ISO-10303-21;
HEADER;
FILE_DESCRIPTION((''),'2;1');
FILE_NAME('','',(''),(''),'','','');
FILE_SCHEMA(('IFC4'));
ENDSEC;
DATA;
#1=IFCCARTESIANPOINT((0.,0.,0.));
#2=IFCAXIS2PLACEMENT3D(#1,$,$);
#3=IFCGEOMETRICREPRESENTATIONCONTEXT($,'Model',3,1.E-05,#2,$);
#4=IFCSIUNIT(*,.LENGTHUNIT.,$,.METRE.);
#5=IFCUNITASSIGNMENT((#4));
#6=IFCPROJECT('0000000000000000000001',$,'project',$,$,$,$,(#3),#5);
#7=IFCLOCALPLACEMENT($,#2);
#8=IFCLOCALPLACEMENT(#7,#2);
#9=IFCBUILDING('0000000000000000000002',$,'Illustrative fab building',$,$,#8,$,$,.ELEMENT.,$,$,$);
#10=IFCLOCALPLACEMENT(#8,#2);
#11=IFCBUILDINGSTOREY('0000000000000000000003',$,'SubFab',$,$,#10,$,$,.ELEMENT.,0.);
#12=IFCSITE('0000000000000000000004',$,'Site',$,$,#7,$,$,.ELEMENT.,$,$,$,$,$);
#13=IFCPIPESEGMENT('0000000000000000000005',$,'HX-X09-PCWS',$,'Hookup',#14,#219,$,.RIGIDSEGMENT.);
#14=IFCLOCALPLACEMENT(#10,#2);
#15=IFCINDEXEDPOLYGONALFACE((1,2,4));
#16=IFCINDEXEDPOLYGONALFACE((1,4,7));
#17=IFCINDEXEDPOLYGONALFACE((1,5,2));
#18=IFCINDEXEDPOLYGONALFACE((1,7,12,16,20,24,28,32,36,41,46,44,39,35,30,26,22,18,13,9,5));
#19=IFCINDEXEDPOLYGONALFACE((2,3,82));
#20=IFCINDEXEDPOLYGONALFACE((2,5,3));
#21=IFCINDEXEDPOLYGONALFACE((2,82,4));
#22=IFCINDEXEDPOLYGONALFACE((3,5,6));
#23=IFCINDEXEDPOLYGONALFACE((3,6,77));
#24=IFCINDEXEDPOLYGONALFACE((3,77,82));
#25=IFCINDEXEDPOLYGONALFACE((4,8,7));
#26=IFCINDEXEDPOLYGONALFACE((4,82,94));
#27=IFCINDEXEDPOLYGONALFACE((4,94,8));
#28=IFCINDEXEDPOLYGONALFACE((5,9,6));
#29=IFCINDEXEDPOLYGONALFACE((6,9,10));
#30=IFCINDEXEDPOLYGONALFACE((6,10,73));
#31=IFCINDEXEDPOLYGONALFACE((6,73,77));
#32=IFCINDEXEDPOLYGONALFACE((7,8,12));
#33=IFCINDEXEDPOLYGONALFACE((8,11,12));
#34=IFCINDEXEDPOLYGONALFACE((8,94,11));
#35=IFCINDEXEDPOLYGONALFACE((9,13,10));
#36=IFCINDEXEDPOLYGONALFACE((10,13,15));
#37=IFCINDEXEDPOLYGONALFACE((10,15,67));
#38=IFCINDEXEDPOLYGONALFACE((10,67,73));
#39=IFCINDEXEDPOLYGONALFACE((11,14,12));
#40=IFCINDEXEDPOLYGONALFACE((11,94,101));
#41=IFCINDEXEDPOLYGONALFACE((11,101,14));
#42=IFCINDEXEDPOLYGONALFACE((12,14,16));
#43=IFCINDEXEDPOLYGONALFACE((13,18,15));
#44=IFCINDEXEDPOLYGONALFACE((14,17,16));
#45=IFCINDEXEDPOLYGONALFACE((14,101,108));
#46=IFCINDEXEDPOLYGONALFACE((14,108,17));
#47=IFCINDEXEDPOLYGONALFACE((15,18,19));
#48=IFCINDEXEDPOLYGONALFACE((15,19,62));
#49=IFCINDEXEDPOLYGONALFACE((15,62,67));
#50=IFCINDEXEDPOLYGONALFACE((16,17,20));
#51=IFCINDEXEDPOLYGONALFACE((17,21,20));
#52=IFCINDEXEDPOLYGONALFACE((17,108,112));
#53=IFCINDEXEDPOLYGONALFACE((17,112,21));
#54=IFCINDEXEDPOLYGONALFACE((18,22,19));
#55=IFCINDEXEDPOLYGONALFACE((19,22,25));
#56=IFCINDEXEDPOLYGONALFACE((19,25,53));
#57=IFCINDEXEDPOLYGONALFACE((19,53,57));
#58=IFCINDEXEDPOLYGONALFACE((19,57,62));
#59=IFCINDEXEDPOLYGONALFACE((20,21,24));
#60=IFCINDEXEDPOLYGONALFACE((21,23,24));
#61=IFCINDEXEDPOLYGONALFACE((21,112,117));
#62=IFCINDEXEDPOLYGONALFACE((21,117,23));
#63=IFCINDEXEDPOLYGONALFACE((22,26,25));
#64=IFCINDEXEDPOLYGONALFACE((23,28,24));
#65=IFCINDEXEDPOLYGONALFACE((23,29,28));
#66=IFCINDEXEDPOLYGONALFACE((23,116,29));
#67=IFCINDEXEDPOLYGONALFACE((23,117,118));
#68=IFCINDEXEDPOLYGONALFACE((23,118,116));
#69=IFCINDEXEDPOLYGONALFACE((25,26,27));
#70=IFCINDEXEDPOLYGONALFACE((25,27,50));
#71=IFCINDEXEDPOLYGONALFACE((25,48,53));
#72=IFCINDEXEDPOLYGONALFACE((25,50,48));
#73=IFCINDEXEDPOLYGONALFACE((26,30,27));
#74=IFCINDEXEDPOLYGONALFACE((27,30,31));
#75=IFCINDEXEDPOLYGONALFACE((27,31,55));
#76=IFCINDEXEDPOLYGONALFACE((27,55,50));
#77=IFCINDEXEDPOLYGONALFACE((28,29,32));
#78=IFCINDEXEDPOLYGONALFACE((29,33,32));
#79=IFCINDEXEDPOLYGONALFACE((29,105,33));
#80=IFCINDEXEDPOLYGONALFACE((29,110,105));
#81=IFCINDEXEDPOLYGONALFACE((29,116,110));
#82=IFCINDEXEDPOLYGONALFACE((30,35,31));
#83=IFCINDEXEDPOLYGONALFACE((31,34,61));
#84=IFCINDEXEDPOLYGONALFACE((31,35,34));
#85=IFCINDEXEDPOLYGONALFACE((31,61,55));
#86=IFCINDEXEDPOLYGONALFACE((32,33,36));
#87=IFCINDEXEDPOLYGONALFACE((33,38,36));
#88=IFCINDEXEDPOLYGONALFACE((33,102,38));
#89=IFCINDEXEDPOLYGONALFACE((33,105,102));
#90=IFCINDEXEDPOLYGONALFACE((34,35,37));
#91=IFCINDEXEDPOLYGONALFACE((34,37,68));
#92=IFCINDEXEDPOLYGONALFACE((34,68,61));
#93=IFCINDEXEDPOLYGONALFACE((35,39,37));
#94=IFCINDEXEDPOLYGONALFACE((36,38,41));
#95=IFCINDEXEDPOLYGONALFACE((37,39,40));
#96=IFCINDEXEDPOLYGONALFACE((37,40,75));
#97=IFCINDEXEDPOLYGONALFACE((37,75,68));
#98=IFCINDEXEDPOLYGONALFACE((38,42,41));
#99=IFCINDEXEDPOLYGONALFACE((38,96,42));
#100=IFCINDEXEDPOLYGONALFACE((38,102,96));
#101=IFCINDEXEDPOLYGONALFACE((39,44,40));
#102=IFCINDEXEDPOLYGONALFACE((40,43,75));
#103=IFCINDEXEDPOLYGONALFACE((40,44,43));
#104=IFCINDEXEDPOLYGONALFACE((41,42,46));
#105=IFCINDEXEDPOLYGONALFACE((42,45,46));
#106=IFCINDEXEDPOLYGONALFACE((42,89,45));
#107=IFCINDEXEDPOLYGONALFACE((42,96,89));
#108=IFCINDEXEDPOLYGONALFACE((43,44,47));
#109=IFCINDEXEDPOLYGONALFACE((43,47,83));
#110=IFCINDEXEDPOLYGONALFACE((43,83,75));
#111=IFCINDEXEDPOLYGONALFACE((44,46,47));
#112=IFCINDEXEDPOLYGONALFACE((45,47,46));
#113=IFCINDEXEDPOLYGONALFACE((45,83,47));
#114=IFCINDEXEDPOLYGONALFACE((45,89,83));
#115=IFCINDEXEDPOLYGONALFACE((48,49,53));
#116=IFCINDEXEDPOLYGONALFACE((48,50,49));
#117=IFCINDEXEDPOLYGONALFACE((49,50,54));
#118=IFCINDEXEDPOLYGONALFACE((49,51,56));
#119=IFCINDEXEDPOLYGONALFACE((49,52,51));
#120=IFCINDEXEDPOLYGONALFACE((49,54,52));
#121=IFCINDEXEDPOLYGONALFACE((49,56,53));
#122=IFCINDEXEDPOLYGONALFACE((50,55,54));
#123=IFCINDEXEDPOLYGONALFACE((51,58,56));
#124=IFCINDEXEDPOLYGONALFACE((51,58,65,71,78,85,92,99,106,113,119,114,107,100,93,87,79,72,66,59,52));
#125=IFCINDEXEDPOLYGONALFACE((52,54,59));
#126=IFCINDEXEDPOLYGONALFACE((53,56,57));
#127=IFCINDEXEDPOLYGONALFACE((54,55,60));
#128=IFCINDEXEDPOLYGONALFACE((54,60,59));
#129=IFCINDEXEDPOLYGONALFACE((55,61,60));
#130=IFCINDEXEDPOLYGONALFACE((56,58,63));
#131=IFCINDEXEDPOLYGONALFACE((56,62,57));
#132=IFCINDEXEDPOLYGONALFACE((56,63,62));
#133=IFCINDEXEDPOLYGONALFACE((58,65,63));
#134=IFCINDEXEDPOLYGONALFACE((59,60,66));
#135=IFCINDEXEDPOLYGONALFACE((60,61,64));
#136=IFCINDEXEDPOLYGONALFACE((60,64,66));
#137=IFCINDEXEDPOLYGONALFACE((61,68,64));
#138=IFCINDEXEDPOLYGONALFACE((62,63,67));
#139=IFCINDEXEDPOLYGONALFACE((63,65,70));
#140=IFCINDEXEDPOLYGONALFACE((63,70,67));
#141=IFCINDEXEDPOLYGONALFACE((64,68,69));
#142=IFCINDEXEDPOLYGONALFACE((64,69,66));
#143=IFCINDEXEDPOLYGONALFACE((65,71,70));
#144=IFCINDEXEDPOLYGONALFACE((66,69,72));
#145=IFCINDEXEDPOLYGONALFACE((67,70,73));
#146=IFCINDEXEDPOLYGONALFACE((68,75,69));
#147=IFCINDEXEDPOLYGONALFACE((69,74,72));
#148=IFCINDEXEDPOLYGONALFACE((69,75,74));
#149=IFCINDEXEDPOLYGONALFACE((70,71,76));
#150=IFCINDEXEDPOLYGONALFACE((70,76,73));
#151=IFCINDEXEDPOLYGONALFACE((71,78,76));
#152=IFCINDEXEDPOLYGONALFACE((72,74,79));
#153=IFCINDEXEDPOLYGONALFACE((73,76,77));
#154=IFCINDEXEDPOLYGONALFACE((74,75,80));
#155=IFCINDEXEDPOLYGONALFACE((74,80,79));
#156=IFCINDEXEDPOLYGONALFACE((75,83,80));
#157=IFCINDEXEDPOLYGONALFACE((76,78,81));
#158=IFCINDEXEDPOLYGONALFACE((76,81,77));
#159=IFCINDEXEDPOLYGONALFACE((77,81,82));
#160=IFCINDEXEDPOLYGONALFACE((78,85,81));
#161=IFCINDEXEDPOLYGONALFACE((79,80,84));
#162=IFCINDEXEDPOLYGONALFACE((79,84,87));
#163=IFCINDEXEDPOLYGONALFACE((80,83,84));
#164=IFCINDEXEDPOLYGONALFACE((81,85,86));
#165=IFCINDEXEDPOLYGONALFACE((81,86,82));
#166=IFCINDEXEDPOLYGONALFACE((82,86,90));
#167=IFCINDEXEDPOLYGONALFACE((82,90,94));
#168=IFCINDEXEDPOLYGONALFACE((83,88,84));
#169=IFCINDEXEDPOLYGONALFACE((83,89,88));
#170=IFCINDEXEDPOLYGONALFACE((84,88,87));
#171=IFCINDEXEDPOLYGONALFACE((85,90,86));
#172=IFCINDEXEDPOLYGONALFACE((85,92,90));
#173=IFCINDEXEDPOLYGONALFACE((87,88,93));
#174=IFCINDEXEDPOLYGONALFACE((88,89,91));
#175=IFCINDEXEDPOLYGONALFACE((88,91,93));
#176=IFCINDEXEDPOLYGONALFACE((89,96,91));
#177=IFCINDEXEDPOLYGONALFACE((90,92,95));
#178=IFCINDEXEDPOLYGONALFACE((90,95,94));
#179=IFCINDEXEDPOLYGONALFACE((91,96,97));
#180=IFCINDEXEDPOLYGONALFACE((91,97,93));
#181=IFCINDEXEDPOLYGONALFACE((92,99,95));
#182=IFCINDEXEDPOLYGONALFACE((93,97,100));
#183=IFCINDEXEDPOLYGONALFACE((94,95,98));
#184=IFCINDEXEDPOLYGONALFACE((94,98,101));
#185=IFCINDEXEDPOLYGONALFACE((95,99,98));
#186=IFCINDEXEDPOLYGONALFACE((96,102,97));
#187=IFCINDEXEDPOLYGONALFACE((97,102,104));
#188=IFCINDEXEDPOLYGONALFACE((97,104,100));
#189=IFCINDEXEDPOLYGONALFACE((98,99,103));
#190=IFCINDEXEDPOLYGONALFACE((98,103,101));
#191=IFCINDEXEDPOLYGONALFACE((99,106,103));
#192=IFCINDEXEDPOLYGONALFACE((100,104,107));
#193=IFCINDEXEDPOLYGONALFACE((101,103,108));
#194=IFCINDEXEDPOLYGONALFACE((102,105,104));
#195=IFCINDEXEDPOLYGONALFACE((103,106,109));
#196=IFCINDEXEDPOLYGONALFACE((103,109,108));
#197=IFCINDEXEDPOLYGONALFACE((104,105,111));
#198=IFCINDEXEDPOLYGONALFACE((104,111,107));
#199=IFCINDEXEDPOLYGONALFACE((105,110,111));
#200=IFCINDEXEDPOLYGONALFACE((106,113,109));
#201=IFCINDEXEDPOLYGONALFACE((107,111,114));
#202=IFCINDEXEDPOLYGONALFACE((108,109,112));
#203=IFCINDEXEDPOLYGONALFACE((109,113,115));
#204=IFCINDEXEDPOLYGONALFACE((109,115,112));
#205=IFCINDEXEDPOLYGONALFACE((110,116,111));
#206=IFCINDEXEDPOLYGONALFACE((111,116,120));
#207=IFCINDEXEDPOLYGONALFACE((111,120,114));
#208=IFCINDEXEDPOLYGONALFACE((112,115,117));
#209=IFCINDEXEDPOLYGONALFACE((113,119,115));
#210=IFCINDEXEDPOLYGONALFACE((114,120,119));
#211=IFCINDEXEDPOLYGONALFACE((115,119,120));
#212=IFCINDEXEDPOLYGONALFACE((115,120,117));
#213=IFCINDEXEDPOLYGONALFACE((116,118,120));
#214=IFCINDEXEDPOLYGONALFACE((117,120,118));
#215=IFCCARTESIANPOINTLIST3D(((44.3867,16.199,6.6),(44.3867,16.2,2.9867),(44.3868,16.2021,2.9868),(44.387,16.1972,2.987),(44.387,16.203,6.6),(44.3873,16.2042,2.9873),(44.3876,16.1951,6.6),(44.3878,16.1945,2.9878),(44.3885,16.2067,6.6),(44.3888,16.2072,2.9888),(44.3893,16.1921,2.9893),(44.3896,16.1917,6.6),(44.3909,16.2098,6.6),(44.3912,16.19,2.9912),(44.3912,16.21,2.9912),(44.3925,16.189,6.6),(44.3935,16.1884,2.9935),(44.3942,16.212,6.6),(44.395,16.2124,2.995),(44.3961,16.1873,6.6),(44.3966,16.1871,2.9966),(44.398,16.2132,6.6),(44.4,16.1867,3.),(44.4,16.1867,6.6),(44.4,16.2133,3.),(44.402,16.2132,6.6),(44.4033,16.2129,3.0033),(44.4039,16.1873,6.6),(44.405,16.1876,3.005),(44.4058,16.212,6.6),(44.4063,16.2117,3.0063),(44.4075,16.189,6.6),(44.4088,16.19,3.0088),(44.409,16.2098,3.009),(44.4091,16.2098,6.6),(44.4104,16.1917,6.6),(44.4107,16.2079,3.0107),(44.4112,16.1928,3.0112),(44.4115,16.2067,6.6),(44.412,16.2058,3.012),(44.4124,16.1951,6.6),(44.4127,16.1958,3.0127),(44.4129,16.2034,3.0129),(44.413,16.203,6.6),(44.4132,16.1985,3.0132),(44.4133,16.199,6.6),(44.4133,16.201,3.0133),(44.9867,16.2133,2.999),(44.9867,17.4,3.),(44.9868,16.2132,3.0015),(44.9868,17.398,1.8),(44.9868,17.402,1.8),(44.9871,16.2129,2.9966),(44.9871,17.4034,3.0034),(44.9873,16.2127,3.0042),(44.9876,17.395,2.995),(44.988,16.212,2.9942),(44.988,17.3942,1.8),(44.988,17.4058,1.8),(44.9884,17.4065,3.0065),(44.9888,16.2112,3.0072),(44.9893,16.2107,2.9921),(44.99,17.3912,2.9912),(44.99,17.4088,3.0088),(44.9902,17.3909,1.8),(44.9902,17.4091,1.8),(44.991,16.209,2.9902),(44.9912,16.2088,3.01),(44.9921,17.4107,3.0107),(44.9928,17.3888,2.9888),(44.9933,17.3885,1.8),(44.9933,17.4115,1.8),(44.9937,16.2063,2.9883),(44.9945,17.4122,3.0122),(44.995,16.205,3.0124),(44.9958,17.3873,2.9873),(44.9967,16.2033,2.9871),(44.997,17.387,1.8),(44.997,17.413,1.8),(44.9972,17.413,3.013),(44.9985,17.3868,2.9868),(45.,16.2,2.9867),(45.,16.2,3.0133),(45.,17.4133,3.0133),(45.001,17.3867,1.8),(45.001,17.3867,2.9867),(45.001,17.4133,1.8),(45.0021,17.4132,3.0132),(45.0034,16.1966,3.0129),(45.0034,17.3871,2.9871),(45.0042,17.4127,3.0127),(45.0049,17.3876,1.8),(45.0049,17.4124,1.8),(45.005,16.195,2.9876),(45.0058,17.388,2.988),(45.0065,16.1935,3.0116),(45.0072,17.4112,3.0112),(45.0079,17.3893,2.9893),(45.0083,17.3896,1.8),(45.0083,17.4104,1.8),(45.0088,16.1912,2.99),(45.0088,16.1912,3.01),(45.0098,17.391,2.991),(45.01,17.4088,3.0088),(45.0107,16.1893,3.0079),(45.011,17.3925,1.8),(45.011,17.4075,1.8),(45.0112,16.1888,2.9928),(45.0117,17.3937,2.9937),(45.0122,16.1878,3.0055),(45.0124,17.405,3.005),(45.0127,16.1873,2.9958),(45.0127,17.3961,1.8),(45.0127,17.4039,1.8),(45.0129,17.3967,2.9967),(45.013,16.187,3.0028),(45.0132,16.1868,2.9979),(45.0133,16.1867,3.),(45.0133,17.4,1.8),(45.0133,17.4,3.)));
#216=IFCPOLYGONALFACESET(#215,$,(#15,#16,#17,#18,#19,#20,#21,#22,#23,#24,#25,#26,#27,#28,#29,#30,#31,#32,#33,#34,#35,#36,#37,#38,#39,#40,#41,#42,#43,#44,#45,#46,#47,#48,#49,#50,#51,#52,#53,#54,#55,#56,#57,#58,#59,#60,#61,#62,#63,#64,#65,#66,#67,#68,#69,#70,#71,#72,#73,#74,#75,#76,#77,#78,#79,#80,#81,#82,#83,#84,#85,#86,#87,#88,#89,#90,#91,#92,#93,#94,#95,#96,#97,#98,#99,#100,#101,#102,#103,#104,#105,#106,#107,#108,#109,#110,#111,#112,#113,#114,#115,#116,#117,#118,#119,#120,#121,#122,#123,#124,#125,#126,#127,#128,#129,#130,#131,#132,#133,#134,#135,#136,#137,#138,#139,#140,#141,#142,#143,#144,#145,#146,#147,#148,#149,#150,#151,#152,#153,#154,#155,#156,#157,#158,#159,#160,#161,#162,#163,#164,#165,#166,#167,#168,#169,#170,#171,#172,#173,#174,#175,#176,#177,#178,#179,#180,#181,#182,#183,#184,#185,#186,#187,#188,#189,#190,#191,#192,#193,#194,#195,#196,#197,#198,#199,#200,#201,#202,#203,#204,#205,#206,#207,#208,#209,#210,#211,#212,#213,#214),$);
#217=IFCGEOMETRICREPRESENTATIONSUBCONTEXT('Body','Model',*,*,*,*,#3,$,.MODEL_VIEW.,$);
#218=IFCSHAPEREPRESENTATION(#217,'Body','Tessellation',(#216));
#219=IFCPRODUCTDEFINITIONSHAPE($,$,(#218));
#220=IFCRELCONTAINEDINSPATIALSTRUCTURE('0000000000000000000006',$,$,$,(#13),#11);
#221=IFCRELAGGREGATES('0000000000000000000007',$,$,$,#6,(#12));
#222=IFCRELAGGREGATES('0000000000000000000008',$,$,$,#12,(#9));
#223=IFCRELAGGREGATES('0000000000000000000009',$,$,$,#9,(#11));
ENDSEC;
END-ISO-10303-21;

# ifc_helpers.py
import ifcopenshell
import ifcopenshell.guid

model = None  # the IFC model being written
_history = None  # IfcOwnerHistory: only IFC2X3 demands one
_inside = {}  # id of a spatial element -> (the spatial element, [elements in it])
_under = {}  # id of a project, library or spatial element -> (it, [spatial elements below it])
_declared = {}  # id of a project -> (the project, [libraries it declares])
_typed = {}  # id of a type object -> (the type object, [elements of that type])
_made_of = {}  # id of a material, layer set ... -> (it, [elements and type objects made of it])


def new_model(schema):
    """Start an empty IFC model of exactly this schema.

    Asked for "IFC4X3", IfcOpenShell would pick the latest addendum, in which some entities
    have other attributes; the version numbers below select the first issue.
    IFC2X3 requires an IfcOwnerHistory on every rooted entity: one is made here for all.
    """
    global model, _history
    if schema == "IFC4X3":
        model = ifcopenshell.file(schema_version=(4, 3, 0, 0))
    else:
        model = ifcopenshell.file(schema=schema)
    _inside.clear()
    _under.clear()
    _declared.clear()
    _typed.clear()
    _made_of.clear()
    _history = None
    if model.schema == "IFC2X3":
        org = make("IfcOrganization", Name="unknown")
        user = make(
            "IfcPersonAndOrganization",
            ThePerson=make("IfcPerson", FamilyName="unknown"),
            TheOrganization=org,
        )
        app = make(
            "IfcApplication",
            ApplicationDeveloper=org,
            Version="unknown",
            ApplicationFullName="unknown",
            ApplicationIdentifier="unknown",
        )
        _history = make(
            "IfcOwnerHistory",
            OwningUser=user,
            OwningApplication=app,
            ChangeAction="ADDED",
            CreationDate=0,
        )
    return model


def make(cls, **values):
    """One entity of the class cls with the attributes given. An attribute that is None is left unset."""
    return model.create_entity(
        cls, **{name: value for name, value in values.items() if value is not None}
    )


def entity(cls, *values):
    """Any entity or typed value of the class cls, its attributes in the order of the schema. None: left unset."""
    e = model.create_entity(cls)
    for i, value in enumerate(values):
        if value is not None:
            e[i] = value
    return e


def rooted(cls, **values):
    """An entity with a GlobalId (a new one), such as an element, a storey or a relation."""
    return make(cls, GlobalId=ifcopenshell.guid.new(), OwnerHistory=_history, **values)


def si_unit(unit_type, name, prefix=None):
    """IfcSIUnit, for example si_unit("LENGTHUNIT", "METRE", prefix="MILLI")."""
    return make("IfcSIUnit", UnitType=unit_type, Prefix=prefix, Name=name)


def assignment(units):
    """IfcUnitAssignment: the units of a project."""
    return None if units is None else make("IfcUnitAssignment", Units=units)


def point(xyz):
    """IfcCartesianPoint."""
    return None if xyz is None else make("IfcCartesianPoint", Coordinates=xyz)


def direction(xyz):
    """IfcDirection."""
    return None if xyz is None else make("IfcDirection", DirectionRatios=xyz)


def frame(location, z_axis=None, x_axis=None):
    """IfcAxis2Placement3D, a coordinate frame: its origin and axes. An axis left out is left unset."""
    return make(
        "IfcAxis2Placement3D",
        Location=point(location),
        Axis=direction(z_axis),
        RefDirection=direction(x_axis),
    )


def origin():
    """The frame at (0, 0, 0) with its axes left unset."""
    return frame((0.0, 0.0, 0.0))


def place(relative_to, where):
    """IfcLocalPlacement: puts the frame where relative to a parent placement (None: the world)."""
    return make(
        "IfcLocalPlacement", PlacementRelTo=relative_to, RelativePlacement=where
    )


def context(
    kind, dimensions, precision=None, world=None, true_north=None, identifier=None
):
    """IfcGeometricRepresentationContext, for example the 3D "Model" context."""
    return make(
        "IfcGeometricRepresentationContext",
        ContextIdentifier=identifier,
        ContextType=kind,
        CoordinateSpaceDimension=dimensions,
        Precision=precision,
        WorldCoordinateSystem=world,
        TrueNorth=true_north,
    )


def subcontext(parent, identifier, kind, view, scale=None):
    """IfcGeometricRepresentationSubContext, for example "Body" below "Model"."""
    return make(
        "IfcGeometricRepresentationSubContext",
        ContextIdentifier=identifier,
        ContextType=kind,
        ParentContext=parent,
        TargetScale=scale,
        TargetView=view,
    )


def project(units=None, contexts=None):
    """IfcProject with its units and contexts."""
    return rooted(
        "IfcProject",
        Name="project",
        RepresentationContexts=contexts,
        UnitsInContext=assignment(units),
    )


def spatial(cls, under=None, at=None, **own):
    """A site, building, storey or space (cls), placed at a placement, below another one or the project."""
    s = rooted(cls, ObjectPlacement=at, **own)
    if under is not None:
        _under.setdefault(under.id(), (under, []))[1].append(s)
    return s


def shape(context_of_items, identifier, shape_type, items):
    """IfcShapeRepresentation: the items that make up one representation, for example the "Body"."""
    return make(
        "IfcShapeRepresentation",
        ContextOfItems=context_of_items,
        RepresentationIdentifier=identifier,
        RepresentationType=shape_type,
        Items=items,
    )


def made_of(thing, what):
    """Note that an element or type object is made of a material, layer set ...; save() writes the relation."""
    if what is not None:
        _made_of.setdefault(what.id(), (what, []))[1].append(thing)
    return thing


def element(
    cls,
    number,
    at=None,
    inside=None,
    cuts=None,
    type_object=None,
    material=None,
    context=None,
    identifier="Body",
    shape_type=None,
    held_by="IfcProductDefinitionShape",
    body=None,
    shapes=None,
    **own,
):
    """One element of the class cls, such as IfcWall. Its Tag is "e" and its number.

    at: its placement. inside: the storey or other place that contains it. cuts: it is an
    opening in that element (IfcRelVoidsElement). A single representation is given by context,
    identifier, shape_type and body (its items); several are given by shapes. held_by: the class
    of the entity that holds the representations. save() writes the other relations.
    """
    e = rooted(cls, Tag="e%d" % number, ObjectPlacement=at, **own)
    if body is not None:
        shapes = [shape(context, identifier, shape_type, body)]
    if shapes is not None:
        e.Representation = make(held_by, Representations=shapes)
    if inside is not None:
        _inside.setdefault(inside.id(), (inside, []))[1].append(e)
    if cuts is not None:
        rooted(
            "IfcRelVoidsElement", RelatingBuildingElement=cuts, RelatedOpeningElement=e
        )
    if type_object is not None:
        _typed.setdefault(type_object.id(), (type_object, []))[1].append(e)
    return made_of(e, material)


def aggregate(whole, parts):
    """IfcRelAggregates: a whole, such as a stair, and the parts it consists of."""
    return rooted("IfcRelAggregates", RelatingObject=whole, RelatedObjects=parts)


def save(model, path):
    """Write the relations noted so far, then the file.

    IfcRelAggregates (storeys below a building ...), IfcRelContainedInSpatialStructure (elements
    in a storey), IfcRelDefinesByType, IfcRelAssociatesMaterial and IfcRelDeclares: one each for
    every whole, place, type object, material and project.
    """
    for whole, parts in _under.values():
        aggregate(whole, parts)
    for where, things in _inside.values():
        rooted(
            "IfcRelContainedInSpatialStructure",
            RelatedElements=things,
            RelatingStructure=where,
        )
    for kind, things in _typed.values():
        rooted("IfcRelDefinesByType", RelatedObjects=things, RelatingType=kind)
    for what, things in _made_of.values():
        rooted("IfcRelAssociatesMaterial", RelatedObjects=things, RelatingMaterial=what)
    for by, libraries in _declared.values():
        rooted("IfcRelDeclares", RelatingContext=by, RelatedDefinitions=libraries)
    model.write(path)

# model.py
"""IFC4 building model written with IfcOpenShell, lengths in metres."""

from ifc_helpers import new_model, entity, si_unit, origin, place, context, subcontext, project, spatial, element, save


model = new_model("IFC4")

# Units and contexts
model_context = context("Model", 3, precision=1e-05, world=origin())
body_context = subcontext(model_context, "Body", "Model", "MODEL_VIEW")
ifc_project = project(units=[si_unit("LENGTHUNIT", "METRE")], contexts=[model_context])

# Site, building, storey
site_placement = place(None, origin())
site = spatial("IfcSite", under=ifc_project, at=site_placement, Name="Site", CompositionType="ELEMENT")
building_placement = place(site_placement, origin())
building = spatial("IfcBuilding", under=site, at=building_placement, Name="Illustrative fab building", CompositionType="ELEMENT")
storey_placement = place(building_placement, origin())
storey = spatial("IfcBuildingStorey", under=building, at=storey_placement, Name="SubFab", CompositionType="ELEMENT", Elevation=0.0)

# Pipe segment
pipe_segment_1_placement = place(storey_placement, origin())
element("IfcPipeSegment", 1, at=pipe_segment_1_placement, inside=storey, Name="HX-X09-PCWS", ObjectType="Hookup", PredefinedType="RIGIDSEGMENT", context=body_context, shape_type="AdvancedSweptSolid", body=[
    entity("IfcSweptDiskSolid", entity("IfcPolyline", [entity("IfcCartesianPoint", [45.0, 17.4, 1.8]), entity("IfcCartesianPoint", [45.0, 17.4, 3.0]), entity("IfcCartesianPoint", [45.0, 16.2, 3.0]), entity("IfcCartesianPoint", [44.4, 16.2, 3.0]), entity("IfcCartesianPoint", [44.4, 16.2, 6.6])]), 0.0133),
])

save(model, "model.ifc")
